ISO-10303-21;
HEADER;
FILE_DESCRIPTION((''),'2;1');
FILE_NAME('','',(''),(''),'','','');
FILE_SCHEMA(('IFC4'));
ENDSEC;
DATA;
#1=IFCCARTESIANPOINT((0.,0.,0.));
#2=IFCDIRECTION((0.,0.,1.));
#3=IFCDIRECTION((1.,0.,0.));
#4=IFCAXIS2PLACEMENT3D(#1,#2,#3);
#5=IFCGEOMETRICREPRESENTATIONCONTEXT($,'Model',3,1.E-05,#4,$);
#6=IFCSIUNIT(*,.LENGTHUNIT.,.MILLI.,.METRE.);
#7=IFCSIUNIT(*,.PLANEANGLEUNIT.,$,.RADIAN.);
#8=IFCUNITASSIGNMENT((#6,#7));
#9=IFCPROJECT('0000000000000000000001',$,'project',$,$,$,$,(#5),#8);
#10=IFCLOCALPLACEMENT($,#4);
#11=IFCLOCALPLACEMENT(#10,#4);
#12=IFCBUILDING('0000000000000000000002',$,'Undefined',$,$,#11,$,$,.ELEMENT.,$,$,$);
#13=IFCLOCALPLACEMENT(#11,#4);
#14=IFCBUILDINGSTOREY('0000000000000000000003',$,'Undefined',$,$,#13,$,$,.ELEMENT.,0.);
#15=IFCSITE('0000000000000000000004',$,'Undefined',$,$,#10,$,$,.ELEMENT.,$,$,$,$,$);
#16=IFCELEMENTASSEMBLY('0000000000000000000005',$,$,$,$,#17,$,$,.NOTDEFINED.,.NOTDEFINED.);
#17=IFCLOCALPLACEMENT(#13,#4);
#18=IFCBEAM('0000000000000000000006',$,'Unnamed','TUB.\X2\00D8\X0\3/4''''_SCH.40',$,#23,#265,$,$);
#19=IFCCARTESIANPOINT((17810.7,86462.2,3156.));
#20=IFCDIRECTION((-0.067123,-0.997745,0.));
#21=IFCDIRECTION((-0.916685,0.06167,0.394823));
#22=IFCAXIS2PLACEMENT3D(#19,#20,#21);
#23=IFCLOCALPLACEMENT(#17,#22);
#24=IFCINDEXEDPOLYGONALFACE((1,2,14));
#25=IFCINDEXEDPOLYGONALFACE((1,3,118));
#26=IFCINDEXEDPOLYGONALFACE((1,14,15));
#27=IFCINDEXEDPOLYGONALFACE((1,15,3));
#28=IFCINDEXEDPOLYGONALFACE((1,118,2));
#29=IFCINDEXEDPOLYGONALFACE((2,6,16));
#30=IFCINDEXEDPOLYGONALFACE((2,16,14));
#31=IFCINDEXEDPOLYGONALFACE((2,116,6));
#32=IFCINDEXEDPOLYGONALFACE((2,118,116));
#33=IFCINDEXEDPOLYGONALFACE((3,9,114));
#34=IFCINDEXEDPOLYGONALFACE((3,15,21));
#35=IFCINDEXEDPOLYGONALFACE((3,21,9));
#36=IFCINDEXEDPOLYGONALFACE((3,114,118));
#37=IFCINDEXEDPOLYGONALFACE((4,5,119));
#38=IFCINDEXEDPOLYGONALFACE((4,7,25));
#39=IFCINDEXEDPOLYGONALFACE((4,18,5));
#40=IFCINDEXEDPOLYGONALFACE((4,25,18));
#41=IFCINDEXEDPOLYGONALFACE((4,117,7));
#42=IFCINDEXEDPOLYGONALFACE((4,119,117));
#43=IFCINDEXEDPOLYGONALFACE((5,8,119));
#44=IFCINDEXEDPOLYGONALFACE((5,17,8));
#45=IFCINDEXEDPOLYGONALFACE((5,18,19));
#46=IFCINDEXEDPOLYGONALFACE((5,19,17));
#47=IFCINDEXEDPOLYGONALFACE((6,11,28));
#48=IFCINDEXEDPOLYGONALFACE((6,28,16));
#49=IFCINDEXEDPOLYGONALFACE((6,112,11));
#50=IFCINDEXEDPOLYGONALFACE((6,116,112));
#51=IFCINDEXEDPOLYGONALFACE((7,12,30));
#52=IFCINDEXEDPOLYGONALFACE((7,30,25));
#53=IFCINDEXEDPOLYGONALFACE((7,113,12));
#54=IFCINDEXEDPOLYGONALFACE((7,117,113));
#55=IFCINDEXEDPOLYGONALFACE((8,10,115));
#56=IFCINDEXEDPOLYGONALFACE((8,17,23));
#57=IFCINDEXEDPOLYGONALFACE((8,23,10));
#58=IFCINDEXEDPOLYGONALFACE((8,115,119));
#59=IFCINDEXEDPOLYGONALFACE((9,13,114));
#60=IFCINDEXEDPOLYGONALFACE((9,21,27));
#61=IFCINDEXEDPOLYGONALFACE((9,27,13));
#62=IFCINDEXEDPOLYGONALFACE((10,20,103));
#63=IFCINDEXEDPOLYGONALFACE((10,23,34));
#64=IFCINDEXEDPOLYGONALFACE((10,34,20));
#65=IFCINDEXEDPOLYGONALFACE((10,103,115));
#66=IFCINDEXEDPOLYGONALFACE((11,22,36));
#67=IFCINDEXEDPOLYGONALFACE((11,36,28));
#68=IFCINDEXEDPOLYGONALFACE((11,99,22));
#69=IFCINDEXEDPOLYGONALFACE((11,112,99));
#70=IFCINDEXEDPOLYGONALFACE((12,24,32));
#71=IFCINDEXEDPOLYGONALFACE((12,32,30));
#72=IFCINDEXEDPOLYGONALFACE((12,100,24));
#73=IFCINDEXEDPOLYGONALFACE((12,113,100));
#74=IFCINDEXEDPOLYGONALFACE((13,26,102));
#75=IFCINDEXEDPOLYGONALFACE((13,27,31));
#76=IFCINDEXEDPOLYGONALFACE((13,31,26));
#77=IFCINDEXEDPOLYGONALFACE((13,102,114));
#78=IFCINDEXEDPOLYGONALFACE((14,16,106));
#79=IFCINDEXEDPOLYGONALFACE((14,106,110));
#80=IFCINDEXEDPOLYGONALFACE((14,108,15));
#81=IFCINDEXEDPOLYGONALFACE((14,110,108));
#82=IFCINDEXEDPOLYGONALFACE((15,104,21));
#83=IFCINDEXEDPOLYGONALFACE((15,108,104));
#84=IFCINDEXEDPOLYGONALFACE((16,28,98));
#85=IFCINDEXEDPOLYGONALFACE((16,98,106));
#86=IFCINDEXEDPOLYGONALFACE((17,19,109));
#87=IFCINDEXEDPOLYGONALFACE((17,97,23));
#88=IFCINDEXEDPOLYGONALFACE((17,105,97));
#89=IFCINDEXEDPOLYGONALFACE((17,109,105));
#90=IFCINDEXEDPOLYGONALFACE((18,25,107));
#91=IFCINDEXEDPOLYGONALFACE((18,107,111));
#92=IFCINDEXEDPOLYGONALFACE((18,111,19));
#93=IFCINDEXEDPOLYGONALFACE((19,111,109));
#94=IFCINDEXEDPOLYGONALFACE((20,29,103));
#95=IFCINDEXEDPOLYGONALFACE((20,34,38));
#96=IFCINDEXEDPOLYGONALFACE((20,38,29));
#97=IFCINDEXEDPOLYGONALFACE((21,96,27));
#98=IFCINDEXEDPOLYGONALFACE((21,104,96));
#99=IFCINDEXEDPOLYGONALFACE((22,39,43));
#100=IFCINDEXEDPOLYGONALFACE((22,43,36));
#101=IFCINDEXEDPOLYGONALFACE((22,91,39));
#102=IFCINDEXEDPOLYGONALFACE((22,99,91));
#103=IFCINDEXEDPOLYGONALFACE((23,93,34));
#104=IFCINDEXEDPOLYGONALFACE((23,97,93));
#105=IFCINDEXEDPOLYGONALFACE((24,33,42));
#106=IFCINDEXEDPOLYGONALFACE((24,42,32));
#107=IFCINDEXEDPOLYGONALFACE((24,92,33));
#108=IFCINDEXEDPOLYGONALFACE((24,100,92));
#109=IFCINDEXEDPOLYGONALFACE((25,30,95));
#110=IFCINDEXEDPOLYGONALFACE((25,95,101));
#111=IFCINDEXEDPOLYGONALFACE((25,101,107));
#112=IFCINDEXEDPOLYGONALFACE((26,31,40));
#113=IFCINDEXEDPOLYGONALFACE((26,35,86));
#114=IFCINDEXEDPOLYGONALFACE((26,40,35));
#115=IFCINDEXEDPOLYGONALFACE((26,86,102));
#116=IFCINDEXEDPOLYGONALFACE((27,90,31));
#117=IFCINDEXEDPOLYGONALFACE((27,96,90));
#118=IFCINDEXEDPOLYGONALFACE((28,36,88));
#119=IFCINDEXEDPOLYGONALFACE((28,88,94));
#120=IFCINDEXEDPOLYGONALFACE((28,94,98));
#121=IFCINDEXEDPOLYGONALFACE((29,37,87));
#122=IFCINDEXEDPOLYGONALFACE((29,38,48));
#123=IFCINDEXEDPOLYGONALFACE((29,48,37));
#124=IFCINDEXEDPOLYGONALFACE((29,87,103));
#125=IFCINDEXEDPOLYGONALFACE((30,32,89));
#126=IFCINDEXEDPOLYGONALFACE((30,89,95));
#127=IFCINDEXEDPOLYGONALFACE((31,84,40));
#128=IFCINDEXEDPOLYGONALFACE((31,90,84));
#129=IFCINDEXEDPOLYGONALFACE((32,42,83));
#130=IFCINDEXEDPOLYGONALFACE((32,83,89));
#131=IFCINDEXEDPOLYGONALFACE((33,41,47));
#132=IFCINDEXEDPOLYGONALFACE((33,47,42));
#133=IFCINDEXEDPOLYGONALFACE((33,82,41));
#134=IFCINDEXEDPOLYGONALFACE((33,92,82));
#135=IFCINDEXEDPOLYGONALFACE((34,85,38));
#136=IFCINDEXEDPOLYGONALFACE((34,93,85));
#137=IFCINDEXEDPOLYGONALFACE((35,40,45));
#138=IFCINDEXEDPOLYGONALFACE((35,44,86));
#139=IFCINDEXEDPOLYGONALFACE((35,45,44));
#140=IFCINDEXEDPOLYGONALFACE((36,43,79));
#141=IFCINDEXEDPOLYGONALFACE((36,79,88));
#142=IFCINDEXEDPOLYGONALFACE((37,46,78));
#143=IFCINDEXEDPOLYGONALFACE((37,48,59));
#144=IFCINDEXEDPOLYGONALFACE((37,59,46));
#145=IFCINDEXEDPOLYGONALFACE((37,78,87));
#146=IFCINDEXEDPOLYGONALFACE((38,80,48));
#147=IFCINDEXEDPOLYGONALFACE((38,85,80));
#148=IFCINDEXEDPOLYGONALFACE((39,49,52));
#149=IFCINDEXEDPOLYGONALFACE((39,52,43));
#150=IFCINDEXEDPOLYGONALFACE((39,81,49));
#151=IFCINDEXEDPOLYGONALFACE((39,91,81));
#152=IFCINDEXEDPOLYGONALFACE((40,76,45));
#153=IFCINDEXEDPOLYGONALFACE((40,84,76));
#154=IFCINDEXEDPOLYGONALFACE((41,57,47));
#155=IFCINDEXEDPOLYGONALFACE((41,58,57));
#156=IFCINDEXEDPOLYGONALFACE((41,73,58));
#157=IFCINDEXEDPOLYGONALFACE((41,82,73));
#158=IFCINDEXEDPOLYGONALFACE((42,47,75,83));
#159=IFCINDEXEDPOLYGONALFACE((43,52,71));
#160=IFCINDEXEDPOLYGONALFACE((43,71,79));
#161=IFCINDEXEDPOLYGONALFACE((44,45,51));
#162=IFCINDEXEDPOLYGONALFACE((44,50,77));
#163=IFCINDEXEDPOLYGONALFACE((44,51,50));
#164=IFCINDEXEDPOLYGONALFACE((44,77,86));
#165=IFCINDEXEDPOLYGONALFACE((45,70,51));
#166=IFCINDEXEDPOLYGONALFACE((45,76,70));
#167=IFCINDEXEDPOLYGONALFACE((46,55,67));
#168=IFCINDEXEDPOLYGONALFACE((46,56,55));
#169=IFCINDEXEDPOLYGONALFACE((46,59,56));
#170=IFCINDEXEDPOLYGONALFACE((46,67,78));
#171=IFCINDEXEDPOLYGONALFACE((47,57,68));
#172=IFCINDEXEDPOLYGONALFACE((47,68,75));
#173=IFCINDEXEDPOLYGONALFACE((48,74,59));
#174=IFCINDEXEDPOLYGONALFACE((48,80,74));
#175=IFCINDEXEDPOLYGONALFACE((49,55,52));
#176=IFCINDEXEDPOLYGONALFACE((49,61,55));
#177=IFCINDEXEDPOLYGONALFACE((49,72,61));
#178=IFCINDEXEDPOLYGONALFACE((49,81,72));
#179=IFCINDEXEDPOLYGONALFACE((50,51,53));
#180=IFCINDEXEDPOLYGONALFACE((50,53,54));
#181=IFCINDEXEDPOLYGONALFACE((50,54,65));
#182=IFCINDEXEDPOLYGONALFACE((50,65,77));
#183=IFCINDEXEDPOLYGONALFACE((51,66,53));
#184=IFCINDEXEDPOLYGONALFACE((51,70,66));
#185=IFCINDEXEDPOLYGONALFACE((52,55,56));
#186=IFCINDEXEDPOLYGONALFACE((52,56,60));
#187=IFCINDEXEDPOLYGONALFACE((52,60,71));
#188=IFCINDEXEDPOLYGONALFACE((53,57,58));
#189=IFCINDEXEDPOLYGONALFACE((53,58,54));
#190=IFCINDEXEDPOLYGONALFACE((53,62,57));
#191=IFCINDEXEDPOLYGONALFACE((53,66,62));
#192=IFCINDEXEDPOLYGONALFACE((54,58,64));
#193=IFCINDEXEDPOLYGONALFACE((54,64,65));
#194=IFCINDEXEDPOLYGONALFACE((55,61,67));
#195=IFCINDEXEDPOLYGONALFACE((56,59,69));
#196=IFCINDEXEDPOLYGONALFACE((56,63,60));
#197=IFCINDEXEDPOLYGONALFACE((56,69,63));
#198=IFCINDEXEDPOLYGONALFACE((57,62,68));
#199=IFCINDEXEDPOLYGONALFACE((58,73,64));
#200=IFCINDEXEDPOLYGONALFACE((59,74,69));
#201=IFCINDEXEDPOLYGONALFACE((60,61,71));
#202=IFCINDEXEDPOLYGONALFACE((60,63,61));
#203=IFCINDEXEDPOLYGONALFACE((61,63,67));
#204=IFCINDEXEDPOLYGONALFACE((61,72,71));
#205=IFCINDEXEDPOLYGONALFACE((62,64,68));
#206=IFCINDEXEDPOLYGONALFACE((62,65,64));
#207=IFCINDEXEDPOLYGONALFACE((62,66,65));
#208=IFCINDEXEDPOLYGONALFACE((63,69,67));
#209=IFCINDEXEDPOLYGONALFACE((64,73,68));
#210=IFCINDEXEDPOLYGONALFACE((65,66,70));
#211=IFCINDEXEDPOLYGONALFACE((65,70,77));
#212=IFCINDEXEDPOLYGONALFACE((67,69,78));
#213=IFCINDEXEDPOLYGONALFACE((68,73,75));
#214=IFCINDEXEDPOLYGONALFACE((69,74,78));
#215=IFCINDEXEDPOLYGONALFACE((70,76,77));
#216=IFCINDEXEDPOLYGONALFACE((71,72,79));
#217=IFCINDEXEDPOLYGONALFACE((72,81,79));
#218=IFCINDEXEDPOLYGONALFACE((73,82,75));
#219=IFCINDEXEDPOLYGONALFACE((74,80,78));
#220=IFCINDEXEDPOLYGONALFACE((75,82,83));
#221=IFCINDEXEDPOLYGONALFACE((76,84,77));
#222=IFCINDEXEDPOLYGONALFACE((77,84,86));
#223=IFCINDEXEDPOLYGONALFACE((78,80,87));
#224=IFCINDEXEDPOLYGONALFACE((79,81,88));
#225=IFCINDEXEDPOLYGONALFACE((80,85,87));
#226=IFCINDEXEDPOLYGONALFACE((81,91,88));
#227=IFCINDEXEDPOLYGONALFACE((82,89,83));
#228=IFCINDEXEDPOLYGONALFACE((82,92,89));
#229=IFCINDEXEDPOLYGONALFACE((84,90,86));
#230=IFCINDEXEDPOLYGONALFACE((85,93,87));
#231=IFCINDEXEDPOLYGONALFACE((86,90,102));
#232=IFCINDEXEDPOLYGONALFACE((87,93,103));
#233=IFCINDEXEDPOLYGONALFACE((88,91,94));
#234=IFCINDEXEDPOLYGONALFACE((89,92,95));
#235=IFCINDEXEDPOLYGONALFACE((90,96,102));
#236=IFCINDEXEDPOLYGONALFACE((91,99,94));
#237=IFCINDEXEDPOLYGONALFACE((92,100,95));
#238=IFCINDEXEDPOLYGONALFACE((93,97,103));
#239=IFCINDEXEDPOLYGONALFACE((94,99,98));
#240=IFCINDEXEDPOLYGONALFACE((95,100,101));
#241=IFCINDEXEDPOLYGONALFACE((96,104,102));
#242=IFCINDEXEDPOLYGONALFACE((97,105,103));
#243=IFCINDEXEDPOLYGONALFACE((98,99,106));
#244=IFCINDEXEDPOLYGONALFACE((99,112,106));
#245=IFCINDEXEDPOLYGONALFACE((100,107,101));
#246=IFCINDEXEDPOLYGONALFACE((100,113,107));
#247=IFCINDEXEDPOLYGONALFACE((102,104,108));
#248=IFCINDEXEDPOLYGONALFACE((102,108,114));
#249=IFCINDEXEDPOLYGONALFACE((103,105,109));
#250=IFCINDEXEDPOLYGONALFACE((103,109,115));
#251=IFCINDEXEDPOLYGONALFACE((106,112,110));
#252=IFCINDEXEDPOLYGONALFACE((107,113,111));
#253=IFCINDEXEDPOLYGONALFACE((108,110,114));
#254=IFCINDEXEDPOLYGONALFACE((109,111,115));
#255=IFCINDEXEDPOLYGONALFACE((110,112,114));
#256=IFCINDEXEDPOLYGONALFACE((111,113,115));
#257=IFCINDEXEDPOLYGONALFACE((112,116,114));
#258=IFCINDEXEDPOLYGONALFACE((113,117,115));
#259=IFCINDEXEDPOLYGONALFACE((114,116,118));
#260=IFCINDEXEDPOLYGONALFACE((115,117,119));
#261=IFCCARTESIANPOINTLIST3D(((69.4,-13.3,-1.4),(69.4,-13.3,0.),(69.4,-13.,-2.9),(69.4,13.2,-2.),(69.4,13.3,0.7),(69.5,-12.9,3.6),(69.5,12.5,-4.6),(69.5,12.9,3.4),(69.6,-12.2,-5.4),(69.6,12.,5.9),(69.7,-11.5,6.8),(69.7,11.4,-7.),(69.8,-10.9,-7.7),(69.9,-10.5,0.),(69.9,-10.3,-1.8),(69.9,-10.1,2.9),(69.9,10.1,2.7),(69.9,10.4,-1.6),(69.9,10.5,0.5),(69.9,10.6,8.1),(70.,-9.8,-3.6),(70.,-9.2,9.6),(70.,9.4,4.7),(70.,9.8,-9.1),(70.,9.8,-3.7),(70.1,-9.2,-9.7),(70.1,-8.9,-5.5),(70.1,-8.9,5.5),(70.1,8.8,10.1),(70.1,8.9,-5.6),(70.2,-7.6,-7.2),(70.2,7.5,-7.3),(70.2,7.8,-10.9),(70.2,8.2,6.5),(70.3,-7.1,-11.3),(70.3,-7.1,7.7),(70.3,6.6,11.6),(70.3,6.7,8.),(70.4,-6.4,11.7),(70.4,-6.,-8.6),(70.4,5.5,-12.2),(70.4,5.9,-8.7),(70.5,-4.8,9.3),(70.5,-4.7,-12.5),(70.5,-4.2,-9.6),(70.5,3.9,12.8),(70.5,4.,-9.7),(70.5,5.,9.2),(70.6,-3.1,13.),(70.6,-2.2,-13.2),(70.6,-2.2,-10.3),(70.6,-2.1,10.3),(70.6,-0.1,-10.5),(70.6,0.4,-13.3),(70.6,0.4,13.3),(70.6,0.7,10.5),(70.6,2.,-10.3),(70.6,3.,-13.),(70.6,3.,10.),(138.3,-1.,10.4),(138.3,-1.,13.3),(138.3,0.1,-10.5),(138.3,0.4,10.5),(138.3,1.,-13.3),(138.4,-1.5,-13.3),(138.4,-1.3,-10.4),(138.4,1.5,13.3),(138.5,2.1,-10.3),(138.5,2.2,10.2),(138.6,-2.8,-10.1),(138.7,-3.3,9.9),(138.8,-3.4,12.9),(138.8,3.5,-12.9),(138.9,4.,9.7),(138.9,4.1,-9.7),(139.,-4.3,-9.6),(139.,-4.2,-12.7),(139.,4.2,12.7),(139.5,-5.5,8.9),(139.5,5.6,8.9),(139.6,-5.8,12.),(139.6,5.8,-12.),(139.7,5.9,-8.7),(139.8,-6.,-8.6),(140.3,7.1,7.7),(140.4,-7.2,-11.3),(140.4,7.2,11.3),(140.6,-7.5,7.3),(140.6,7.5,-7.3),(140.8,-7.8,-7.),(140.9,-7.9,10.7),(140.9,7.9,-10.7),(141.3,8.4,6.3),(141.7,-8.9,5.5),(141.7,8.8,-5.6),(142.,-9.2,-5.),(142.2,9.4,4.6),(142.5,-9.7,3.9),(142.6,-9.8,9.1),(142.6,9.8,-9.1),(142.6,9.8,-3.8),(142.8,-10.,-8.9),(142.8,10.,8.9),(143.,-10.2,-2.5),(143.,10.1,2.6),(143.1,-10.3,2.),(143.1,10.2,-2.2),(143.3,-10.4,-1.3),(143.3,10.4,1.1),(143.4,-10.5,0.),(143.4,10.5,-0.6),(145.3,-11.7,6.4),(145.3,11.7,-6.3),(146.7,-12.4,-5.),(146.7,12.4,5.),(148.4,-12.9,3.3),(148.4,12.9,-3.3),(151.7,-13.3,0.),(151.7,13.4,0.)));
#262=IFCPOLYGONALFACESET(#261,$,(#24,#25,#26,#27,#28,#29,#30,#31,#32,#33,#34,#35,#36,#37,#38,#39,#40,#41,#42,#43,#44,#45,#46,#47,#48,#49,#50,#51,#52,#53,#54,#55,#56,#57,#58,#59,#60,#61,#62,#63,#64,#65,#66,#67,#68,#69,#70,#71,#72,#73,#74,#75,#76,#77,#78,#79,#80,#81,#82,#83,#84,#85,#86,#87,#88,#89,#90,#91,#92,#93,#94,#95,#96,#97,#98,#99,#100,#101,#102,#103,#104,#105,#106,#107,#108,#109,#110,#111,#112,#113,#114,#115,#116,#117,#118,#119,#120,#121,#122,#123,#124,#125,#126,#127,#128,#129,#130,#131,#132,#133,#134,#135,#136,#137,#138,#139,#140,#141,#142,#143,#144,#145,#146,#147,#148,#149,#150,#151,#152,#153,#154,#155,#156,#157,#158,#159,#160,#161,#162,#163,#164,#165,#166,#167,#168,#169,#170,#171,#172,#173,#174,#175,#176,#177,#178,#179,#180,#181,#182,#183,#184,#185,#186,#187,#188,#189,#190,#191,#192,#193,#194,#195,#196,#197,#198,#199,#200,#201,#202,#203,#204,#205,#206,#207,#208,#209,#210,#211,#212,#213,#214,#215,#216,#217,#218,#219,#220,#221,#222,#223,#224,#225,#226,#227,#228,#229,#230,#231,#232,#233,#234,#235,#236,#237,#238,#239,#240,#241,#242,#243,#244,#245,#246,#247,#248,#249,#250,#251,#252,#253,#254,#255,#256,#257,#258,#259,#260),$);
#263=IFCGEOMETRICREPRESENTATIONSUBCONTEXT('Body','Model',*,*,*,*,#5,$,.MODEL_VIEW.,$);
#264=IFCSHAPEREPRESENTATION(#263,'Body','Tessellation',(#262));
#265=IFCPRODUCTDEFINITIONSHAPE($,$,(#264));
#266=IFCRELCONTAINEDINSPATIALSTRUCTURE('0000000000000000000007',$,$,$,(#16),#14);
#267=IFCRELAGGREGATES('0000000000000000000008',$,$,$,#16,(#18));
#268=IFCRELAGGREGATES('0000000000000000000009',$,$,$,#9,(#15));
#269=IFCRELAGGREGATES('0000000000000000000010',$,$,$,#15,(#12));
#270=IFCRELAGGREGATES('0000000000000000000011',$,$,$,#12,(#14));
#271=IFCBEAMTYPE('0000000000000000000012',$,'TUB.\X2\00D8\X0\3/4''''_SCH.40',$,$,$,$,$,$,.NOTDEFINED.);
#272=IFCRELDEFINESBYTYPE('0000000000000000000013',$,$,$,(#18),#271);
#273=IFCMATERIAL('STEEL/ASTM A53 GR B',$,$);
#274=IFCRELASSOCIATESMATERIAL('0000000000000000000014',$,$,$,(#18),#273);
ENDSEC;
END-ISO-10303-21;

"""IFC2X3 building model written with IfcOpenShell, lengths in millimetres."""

from ifc_helpers import new_model, si_unit, frame, origin_with_axes, origin_2d_with_axis, place, context, subcontext, project, spatial, circle, hollow_circle, extrude, boolean, material, type_object, element, aggregate, save


model = new_model("IFC2X3")

# Units and contexts
model_context = context("Model", 3, precision=1e-05, world=origin_with_axes())
body_context = subcontext(model_context, "Body", "Model", "MODEL_VIEW")
ifc_project = project(units=[si_unit("LENGTHUNIT", "METRE", prefix="MILLI"), si_unit("PLANEANGLEUNIT", "RADIAN")], contexts=[model_context])

# Site, building, storey
site_placement = place(None, origin_with_axes())
site = spatial("IfcSite", under=ifc_project, at=site_placement, Name="Undefined", CompositionType="ELEMENT")
building_placement = place(site_placement, origin_with_axes())
building = spatial("IfcBuilding", under=site, at=building_placement, Name="Undefined", CompositionType="ELEMENT")
storey_placement = place(building_placement, origin_with_axes())
storey = spatial("IfcBuildingStorey", under=building, at=storey_placement, Name="Undefined", CompositionType="ELEMENT", Elevation=0.0)

# Element assembly, beam
assembly_1_placement = place(storey_placement, origin_with_axes())
assembly_1 = element("IfcElementAssembly", 1, at=assembly_1_placement, inside=storey, AssemblyPlace="NOTDEFINED", PredefinedType="NOTDEFINED")
ifc_material_1 = material(Name="STEEL/ASTM A53 GR B")
beam_type_1 = type_object("IfcBeamType", Name="TUB.Ø3/4''_SCH.40", PredefinedType="NOTDEFINED")
beam_1_placement = place(assembly_1_placement, frame((17810.7, 86462.2, 3156.0), z_axis=(-0.067123, -0.997745, 0.0), x_axis=(-0.916685, 0.06167, 0.394823)))
beam_1 = element("IfcBeam", 2, at=beam_1_placement, type_object=beam_type_1, material=ifc_material_1, Name="Unnamed", Description="TUB.Ø3/4''_SCH.40", context=body_context, shape_type="CSG", body=[
    boolean("DIFFERENCE", boolean("DIFFERENCE", extrude(hollow_circle(Radius=13.3, WallThickness=2.9, at=origin_2d_with_axis()), frame((151.7, 0.0, 0.0), z_axis=(-1.0, 0.0, 0.0), x_axis=(0.0, -1.0, 0.0)), (0.0, 0.0, 1.0), 151.7), extrude(circle(Radius=13.3, at=origin_2d_with_axis()), frame((151.7, 0.0, 23.4), z_axis=(-0.000001, 0.0, -1.0), x_axis=(0.0, 1.0, 0.0)), (0.0, 0.0, 1.0), 46.7)), extrude(circle(Radius=70.7, at=origin_2d_with_axis()), frame((0.0, 0.0, -80.7), z_axis=(0.0, 0.0, 1.0), x_axis=(-1.0, 0.0, 0.0)), (0.0, 0.0, 1.0), 161.3)),
])

aggregate(assembly_1, [beam_1])

save(model, "model.ifc")
